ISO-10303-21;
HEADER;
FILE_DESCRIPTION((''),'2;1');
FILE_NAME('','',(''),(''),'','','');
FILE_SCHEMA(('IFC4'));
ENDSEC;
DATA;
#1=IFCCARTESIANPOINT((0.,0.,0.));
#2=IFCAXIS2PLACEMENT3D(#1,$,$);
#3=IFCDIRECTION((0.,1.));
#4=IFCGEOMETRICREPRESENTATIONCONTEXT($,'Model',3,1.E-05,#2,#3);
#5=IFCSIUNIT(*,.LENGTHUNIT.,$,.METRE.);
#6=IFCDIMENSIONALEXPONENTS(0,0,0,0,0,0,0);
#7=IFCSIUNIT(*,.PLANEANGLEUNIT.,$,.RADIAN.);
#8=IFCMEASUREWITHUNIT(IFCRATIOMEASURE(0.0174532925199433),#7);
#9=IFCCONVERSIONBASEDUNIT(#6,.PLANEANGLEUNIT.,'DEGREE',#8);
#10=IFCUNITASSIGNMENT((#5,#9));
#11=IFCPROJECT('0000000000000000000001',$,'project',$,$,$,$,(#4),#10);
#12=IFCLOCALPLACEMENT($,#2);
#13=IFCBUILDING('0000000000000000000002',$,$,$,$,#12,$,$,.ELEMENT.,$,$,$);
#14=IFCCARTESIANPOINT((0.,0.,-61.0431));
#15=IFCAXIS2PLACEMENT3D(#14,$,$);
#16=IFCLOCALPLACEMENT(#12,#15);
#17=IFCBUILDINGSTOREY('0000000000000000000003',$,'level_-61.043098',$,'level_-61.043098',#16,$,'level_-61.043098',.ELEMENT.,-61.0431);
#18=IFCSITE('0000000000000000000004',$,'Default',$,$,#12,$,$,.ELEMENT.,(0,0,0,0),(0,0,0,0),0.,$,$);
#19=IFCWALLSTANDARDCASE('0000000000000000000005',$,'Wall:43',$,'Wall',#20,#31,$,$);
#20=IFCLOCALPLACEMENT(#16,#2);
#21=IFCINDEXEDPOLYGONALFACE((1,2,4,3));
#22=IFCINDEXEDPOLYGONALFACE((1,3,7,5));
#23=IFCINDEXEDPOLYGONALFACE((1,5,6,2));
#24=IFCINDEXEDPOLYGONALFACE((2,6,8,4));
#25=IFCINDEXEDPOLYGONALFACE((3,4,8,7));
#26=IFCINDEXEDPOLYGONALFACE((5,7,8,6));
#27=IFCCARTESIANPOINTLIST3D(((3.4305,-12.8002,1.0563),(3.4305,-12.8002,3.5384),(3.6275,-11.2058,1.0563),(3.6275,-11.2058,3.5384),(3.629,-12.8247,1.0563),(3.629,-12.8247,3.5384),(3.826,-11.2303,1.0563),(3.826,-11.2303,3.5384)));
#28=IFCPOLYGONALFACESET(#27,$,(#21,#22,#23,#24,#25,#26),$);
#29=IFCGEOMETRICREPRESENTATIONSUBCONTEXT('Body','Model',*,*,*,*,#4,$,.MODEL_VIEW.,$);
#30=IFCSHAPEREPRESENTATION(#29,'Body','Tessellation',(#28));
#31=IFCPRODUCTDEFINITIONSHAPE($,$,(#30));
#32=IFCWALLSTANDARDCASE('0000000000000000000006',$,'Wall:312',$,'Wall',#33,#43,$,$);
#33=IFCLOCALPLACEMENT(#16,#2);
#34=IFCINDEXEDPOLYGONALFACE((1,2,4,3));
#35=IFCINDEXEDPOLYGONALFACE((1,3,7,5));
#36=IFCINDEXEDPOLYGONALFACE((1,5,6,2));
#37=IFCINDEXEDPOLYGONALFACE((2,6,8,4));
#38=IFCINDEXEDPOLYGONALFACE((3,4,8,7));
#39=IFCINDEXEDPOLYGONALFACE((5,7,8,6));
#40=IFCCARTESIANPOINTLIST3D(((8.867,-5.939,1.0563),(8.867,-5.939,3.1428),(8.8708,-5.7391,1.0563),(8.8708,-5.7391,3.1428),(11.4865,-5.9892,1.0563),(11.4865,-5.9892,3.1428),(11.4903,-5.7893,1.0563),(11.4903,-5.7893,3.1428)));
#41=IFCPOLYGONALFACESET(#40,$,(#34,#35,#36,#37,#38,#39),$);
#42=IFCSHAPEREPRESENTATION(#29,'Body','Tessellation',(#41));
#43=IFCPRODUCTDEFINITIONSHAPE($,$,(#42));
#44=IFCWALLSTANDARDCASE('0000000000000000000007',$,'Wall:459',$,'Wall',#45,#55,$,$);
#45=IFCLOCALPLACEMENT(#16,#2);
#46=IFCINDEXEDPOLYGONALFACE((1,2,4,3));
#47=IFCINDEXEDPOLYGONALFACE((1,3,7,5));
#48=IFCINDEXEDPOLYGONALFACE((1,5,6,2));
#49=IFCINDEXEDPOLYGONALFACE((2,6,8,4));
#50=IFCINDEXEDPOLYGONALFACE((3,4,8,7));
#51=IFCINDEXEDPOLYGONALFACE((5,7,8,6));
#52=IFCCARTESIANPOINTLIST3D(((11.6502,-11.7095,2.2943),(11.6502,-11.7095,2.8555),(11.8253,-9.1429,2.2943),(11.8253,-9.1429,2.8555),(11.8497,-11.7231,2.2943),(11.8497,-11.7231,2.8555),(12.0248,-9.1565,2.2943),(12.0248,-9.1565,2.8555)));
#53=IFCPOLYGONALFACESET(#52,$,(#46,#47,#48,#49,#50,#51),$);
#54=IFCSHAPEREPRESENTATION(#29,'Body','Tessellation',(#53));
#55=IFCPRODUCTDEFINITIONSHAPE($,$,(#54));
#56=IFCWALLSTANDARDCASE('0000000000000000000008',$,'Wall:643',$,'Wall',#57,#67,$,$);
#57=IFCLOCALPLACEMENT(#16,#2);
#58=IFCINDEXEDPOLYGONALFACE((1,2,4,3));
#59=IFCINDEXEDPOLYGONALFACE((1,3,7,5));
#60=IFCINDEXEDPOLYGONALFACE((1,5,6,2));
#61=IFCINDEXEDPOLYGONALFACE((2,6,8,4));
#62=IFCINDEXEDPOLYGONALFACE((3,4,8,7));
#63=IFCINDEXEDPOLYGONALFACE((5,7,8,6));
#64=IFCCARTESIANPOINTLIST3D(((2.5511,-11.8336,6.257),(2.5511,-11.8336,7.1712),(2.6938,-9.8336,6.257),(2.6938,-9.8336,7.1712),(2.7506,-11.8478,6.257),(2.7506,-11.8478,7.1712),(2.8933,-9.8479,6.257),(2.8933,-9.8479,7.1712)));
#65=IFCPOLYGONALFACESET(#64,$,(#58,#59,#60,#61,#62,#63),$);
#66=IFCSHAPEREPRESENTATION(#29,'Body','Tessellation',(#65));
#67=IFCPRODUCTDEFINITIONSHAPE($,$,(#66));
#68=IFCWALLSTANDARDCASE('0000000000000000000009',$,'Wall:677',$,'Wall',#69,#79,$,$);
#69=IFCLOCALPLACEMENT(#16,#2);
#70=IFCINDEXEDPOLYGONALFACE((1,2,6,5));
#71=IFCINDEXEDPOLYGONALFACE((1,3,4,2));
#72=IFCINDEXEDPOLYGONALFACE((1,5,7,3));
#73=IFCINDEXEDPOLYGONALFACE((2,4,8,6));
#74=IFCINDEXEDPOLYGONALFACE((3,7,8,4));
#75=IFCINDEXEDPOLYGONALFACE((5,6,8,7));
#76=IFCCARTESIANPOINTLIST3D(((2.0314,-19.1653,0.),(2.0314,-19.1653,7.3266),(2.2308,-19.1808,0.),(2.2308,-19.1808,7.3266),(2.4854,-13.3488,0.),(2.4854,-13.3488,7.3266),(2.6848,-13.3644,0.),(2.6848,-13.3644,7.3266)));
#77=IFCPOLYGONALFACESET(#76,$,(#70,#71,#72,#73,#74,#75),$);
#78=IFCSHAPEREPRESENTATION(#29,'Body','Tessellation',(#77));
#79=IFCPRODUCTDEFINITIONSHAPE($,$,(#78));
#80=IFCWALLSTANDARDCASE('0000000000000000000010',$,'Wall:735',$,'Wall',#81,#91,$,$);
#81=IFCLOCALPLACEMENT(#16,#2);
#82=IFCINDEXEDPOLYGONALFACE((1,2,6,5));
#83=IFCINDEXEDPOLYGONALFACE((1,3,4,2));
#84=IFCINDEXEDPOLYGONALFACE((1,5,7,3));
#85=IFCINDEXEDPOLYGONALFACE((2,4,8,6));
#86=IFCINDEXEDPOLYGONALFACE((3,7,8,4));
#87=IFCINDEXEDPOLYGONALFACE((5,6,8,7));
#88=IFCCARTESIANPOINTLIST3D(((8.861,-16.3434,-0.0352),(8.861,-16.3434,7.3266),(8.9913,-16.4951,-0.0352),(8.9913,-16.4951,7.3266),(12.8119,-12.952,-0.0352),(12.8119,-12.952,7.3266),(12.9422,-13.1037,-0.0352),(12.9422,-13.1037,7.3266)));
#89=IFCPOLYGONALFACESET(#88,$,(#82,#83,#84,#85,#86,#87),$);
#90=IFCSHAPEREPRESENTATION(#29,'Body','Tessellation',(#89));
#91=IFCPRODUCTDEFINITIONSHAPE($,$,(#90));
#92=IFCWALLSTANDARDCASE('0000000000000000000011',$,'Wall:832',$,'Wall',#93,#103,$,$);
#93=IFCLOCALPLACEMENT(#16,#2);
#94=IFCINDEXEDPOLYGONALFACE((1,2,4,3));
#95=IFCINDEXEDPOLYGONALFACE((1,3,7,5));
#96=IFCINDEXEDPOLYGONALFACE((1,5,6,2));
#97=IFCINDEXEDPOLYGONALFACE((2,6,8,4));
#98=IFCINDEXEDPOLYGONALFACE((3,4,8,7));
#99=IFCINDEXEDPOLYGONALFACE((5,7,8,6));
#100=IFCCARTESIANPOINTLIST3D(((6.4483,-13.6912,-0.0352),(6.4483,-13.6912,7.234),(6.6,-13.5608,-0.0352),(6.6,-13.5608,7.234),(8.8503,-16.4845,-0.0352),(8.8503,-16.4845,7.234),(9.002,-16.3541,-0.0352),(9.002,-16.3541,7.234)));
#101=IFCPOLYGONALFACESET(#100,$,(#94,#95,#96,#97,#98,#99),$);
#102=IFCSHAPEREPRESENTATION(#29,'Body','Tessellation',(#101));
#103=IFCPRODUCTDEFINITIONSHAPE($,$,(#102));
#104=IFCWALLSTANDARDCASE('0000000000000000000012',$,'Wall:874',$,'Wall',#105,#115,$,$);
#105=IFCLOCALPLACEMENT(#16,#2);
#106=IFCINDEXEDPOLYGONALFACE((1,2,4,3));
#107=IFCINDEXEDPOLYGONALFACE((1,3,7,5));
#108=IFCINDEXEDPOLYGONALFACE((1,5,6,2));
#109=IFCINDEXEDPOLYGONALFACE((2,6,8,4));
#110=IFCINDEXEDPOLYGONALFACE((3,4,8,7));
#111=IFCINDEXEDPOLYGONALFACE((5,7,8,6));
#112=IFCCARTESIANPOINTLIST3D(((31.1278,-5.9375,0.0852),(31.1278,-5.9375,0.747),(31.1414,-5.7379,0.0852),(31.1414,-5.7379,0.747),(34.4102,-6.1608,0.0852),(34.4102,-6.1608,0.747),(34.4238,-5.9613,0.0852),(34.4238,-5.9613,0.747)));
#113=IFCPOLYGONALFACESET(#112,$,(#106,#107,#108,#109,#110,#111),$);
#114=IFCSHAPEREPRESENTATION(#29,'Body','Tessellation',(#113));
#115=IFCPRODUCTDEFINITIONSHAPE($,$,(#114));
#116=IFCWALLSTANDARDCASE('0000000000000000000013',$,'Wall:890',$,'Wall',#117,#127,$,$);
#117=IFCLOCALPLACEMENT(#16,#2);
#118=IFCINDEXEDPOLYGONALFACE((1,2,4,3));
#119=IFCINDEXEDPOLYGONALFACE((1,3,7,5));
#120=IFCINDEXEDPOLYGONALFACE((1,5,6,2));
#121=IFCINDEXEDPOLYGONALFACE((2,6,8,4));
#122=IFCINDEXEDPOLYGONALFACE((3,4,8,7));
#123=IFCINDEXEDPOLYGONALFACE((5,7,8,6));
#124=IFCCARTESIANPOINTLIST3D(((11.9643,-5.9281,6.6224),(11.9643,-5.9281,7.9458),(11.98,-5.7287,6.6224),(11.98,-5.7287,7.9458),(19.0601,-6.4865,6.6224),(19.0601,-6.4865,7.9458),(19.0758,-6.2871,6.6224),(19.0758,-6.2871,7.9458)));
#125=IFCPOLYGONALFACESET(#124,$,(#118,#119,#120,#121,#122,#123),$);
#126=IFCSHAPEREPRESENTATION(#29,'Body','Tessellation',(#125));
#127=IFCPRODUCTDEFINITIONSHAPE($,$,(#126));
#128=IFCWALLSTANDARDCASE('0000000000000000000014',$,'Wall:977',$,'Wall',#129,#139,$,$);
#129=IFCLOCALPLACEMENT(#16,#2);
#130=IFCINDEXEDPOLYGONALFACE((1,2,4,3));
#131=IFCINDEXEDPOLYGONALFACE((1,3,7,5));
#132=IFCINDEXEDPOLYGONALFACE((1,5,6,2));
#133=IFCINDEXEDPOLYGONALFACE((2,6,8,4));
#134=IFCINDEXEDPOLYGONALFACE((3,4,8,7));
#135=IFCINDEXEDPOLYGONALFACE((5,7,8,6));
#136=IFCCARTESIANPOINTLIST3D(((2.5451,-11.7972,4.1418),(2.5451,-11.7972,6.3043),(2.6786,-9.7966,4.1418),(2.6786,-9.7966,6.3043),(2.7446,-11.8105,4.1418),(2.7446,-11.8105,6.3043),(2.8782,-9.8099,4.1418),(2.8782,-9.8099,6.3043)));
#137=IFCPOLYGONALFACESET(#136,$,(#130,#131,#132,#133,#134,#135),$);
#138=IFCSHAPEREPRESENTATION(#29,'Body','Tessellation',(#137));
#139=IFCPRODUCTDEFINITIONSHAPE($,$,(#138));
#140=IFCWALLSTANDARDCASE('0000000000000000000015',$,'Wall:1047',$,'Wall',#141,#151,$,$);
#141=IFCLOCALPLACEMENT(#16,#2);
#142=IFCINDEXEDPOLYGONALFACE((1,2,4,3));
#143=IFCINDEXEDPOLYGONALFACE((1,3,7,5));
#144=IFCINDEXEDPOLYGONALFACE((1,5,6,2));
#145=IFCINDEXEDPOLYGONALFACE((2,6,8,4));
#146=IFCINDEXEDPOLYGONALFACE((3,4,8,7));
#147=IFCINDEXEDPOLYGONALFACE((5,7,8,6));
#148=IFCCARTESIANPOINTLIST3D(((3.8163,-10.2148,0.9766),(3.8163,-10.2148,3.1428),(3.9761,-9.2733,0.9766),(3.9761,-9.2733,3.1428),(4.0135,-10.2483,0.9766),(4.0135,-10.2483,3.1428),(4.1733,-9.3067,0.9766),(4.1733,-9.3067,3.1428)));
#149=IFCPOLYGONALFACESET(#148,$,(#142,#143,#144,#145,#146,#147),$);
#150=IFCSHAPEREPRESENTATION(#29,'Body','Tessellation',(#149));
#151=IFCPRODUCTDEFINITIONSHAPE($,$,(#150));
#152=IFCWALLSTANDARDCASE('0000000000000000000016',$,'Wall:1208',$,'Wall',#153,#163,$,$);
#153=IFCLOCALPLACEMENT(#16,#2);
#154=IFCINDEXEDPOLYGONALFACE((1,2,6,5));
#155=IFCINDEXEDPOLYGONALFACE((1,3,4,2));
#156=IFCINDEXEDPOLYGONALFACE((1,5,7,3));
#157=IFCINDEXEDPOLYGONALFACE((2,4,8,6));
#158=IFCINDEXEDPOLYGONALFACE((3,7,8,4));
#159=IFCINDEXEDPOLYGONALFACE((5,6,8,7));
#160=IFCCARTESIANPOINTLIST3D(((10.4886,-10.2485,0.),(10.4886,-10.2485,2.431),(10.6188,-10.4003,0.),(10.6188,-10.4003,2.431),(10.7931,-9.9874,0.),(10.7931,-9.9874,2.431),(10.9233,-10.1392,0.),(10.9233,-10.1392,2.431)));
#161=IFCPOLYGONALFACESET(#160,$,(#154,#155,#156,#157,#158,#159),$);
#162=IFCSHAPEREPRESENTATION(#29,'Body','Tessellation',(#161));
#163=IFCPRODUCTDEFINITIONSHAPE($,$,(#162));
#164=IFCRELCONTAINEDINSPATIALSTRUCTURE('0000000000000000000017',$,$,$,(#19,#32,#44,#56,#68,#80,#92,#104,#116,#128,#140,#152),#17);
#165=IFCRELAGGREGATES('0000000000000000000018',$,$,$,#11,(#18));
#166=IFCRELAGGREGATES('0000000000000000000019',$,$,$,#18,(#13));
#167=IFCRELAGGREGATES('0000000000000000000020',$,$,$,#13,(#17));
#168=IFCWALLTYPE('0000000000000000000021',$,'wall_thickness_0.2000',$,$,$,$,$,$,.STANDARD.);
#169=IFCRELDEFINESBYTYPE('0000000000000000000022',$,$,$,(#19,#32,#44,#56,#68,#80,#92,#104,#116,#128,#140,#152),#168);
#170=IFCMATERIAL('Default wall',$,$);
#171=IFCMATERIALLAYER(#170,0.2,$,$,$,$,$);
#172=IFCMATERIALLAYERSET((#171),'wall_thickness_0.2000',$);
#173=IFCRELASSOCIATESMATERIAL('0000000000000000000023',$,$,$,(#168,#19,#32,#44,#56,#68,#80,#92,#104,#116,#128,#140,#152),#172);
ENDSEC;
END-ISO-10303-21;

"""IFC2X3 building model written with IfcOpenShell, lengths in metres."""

from ifc_helpers import new_model, entity, si_unit, converted_unit, direction, frame, origin, place, context, subcontext, project, spatial, polyline, outline, extrude, material, layer, layer_set, layer_usage, type_object, element, save


model = new_model("IFC2X3")

# Units and contexts
model_context = context("Model", 3, precision=1e-05, world=origin(), true_north=direction((0.0, 1.0)))
body_context = subcontext(model_context, "Body", "Model", "MODEL_VIEW")
ifc_project = project(units=[si_unit("LENGTHUNIT", "METRE"), converted_unit("PLANEANGLEUNIT", "DEGREE", entity("IfcRatioMeasure", 0.0174532925199433), si_unit("PLANEANGLEUNIT", "RADIAN"), dimensions=[0, 0, 0, 0, 0, 0, 0])], contexts=[model_context])

# Site, building, storey
placement_1 = place(None, origin())
site = spatial("IfcSite", under=ifc_project, at=placement_1, Name="Default", CompositionType="ELEMENT", RefLatitude=(0, 0, 0, 0), RefLongitude=(0, 0, 0, 0), RefElevation=0.0)
building = spatial("IfcBuilding", under=site, at=placement_1, CompositionType="ELEMENT")
storey_placement = place(placement_1, frame((0.0, 0.0, -61.0431)))
storey = spatial("IfcBuildingStorey", under=building, at=storey_placement, Name="level_-61.043098", ObjectType="level_-61.043098", LongName="level_-61.043098", CompositionType="ELEMENT", Elevation=-61.0431)

# Walls
ifc_material_1 = material(Name="Default wall")
ifc_layer = layer(ifc_material_1, 0.2)
ifc_layer_set = layer_set([ifc_layer], Name="wall_thickness_0.2000")
ifc_layer_usage = layer_usage(ifc_layer_set, "AXIS2", "POSITIVE", -0.1)
wall_type = type_object("IfcWallType", Name="wall_thickness_0.2000", PredefinedType="STANDARD", material=ifc_layer_set)
placement_2 = place(placement_1, frame((0.0, 0.0, -59.9868)))
wall_1_placement = place(placement_2, frame((3.7267, -11.2181, 0.0), z_axis=(0.0, 0.0, 1.0), x_axis=(-0.122636, -0.992452, 0.0)))
element("IfcWallStandardCase", 1, at=wall_1_placement, inside=storey, type_object=wall_type, material=ifc_layer_usage, Name="Wall:43", ObjectType="Wall", context=body_context, shape_type="SweptSolid", body=[
    extrude(outline(polyline([(1.6065, -0.1), (1.6065, 0.1), (0.0, 0.1), (0.0, -0.1), (1.6065, -0.1)])), origin(), (0.0, 0.0, 1.0), 2.4821),
])
placement_3 = place(placement_1, frame((0.0, 0.0, -59.9868)))
wall_2_placement = place(placement_3, frame((8.8689, -5.8391, 0.0), z_axis=(0.0, 0.0, 1.0), x_axis=(0.999817, -0.019151, 0.0)))
element("IfcWallStandardCase", 2, at=wall_2_placement, inside=storey, type_object=wall_type, material=ifc_layer_usage, Name="Wall:312", ObjectType="Wall", context=body_context, shape_type="SweptSolid", body=[
    extrude(outline(polyline([(2.62, -0.1), (2.62, 0.1), (0.0, 0.1), (0.0, -0.1), (2.62, -0.1)])), origin(), (0.0, 0.0, 1.0), 2.0865),
])
placement_4 = place(placement_1, frame((0.0, 0.0, -58.7488)))
wall_3_placement = place(placement_4, frame((11.7499, -11.7163, 0.0), z_axis=(0.0, 0.0, 1.0), x_axis=(0.068078, 0.99768, 0.0)))
element("IfcWallStandardCase", 3, at=wall_3_placement, inside=storey, type_object=wall_type, material=ifc_layer_usage, Name="Wall:459", ObjectType="Wall", context=body_context, shape_type="SweptSolid", body=[
    extrude(outline(polyline([(2.5726, -0.1), (2.5726, 0.1), (0.0, 0.1), (0.0, -0.1), (2.5726, -0.1)])), origin(), (0.0, 0.0, 1.0), 0.5612),
])
placement_5 = place(placement_1, frame((0.0, 0.0, -54.7861)))
wall_4_placement = place(placement_5, frame((2.7935, -9.8408, 0.0), z_axis=(0.0, 0.0, 1.0), x_axis=(-0.071174, -0.997464, 0.0)))
element("IfcWallStandardCase", 4, at=wall_4_placement, inside=storey, type_object=wall_type, material=ifc_layer_usage, Name="Wall:643", ObjectType="Wall", context=body_context, shape_type="SweptSolid", body=[
    extrude(outline(polyline([(2.005, -0.1), (2.005, 0.1), (0.0, 0.1), (0.0, -0.1), (2.005, -0.1)])), origin(), (0.0, 0.0, 1.0), 0.9142),
])
wall_5_placement = place(storey_placement, frame((2.5851, -13.3566, 0.0), z_axis=(0.0, 0.0, 1.0), x_axis=(-0.077816, -0.996968, 0.0)))
element("IfcWallStandardCase", 5, at=wall_5_placement, inside=storey, type_object=wall_type, material=ifc_layer_usage, Name="Wall:677", ObjectType="Wall", context=body_context, shape_type="SweptSolid", body=[
    extrude(outline(polyline([(5.8341, -0.1), (5.8341, 0.1), (0.0, 0.1), (0.0, -0.1), (5.8341, -0.1)])), origin(), (0.0, 0.0, 1.0), 7.3266),
])
placement_6 = place(placement_1, frame((0.0, 0.0, -61.0783)))
wall_6_placement = place(placement_6, frame((12.8771, -13.0279, 0.0), z_axis=(0.0, 0.0, 1.0), x_axis=(-0.758791, -0.651334, 0.0)))
element("IfcWallStandardCase", 6, at=wall_6_placement, inside=storey, type_object=wall_type, material=ifc_layer_usage, Name="Wall:735", ObjectType="Wall", context=body_context, shape_type="SweptSolid", body=[
    extrude(outline(polyline([(5.2069, -0.1), (5.2069, 0.1), (0.0, 0.1), (0.0, -0.1), (5.2069, -0.1)])), origin(), (0.0, 0.0, 1.0), 7.3618),
])
placement_7 = place(placement_1, frame((0.0, 0.0, -61.0783)))
wall_7_placement = place(placement_7, frame((6.5241, -13.626, 0.0), z_axis=(0.0, 0.0, 1.0), x_axis=(0.652006, -0.758213, 0.0)))
element("IfcWallStandardCase", 7, at=wall_7_placement, inside=storey, type_object=wall_type, material=ifc_layer_usage, Name="Wall:832", ObjectType="Wall", context=body_context, shape_type="SweptSolid", body=[
    extrude(outline(polyline([(3.684, -0.1), (3.684, 0.1), (0.0, 0.1), (0.0, -0.1), (3.684, -0.1)])), origin(), (0.0, 0.0, 1.0), 7.2692),
])
placement_8 = place(placement_1, frame((0.0, 0.0, -60.9579)))
wall_8_placement = place(placement_8, frame((31.1346, -5.8377, 0.0), z_axis=(0.0, 0.0, 1.0), x_axis=(0.997693, -0.067882, 0.0)))
element("IfcWallStandardCase", 8, at=wall_8_placement, inside=storey, type_object=wall_type, material=ifc_layer_usage, Name="Wall:874", ObjectType="Wall", context=body_context, shape_type="SweptSolid", body=[
    extrude(outline(polyline([(3.29, -0.1), (3.29, 0.1), (0.0, 0.1), (0.0, -0.1), (3.29, -0.1)])), origin(), (0.0, 0.0, 1.0), 0.6618),
])
placement_9 = place(placement_1, frame((0.0, 0.0, -54.4207)))
wall_9_placement = place(placement_9, frame((11.9722, -5.8284, 0.0), z_axis=(0.0, 0.0, 1.0), x_axis=(0.996918, -0.078453, 0.0)))
element("IfcWallStandardCase", 9, at=wall_9_placement, inside=storey, type_object=wall_type, material=ifc_layer_usage, Name="Wall:890", ObjectType="Wall", context=body_context, shape_type="SweptSolid", body=[
    extrude(outline(polyline([(7.1177, -0.1), (7.1177, 0.1), (0.0, 0.1), (0.0, -0.1), (7.1177, -0.1)])), origin(), (0.0, 0.0, 1.0), 1.3234),
])
placement_10 = place(placement_1, frame((0.0, 0.0, -56.9013)))
wall_10_placement = place(placement_10, frame((2.7784, -9.8033, 0.0), z_axis=(0.0, 0.0, 1.0), x_axis=(-0.066595, -0.99778, 0.0)))
element("IfcWallStandardCase", 10, at=wall_10_placement, inside=storey, type_object=wall_type, material=ifc_layer_usage, Name="Wall:977", ObjectType="Wall", context=body_context, shape_type="SweptSolid", body=[
    extrude(outline(polyline([(2.005, -0.1), (2.005, 0.1), (0.0, 0.1), (0.0, -0.1), (2.005, -0.1)])), origin(), (0.0, 0.0, 1.0), 2.1625),
])
placement_11 = place(placement_1, frame((0.0, 0.0, -60.0665)))
wall_11_placement = place(placement_11, frame((3.9149, -10.2315, 0.0), z_axis=(0.0, 0.0, 1.0), x_axis=(0.167306, 0.985905, 0.0)))
element("IfcWallStandardCase", 11, at=wall_11_placement, inside=storey, type_object=wall_type, material=ifc_layer_usage, Name="Wall:1047", ObjectType="Wall", context=body_context, shape_type="SweptSolid", body=[
    extrude(outline(polyline([(0.955, -0.1), (0.955, 0.1), (0.0, 0.1), (0.0, -0.1), (0.955, -0.1)])), origin(), (0.0, 0.0, 1.0), 2.1662),
])
wall_12_placement = place(storey_placement, frame((10.8582, -10.0633, 0.0), z_axis=(0.0, 0.0, 1.0), x_axis=(-0.759124, -0.650946, 0.0)))
element("IfcWallStandardCase", 12, at=wall_12_placement, inside=storey, type_object=wall_type, material=ifc_layer_usage, Name="Wall:1208", ObjectType="Wall", context=body_context, shape_type="SweptSolid", body=[
    extrude(outline(polyline([(0.4011, -0.1), (0.4011, 0.1), (0.0, 0.1), (0.0, -0.1), (0.4011, -0.1)])), origin(), (0.0, 0.0, 1.0), 2.431),
])

save(model, "model.ifc")
